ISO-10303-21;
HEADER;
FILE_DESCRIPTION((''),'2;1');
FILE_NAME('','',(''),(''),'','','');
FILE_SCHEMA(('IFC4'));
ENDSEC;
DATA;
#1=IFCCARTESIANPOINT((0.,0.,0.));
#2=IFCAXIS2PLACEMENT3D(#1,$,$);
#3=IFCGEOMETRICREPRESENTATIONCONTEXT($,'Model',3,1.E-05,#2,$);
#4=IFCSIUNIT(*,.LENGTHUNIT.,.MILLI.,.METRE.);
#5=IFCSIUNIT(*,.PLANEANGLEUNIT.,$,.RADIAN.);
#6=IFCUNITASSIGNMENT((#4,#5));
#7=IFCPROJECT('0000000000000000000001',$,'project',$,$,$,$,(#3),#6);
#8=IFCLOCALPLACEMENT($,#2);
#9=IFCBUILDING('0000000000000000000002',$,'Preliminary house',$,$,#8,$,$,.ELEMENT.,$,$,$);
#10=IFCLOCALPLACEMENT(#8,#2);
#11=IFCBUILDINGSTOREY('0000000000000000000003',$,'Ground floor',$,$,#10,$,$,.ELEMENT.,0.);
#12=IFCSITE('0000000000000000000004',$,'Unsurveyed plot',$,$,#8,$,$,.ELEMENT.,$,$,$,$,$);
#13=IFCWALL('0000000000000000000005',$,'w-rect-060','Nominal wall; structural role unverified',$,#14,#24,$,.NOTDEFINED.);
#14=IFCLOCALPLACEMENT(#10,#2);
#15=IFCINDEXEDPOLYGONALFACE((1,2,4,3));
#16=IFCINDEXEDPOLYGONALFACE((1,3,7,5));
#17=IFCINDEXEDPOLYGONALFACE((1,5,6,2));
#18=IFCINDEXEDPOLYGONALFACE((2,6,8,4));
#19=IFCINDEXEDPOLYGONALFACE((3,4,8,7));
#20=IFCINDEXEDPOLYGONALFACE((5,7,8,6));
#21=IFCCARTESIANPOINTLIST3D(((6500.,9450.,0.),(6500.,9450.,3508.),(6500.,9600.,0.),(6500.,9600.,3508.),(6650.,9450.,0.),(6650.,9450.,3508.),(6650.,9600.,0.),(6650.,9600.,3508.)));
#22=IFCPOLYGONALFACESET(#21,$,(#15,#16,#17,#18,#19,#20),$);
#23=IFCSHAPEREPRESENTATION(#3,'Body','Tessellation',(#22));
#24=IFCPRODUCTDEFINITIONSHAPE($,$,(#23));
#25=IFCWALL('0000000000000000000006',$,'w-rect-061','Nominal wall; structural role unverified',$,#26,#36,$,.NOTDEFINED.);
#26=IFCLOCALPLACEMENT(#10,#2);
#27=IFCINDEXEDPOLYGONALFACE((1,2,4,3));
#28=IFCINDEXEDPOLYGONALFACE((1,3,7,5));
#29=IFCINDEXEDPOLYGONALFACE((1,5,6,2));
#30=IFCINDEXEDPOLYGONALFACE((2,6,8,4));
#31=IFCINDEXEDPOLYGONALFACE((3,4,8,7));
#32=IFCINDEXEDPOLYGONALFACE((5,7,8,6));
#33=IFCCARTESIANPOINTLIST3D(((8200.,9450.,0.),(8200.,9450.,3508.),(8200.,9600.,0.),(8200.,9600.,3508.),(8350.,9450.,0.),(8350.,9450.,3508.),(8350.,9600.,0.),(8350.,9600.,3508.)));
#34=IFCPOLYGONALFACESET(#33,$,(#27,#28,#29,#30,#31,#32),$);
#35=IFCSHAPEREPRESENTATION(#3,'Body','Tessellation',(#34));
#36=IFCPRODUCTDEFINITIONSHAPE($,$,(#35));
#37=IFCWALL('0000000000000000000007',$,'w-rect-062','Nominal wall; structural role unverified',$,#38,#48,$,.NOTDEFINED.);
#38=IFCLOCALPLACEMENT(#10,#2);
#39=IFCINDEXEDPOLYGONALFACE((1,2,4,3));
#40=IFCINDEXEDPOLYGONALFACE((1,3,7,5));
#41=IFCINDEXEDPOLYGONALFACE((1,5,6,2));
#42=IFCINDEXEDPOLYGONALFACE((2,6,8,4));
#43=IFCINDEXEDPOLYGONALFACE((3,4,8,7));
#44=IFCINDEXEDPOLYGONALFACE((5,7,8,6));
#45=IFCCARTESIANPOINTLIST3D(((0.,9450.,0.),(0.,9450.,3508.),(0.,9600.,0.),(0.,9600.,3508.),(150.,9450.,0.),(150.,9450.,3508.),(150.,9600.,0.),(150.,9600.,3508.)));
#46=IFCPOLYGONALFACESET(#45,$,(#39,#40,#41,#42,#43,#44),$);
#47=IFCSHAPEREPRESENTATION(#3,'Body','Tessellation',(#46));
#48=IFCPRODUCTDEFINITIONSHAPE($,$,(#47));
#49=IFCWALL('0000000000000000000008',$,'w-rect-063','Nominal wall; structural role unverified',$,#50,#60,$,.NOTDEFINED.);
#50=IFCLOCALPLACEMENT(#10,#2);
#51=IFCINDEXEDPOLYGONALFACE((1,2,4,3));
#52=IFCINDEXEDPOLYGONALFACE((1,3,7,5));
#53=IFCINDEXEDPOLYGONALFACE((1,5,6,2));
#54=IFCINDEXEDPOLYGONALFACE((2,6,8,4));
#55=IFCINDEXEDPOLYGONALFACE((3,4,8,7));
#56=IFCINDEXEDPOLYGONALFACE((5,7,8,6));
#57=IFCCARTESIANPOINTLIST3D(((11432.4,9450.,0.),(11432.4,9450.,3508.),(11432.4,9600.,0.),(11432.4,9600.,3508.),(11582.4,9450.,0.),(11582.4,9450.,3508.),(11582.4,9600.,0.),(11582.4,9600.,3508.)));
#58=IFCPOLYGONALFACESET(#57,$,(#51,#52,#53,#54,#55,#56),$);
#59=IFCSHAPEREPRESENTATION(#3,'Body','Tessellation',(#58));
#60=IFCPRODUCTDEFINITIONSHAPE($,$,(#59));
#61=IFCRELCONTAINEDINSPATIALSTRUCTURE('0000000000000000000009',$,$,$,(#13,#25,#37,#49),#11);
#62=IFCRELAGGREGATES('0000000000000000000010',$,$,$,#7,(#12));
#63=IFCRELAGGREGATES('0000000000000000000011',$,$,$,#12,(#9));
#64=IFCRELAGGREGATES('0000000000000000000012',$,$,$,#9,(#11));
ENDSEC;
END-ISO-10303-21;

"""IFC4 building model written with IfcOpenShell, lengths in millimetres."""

from ifc_helpers import new_model, si_unit, origin, place, context, project, spatial, polyline, outline, extrude, element, save


model = new_model("IFC4")

# Units and contexts
model_context = context("Model", 3, precision=1e-05, world=origin())
ifc_project = project(units=[si_unit("LENGTHUNIT", "METRE", prefix="MILLI"), si_unit("PLANEANGLEUNIT", "RADIAN")], contexts=[model_context])

# Site, building, storey
placement_1 = place(None, origin())
site = spatial("IfcSite", under=ifc_project, at=placement_1, Name="Unsurveyed plot", CompositionType="ELEMENT")
building = spatial("IfcBuilding", under=site, at=placement_1, Name="Preliminary house", CompositionType="ELEMENT")
placement_2 = place(placement_1, origin())
storey = spatial("IfcBuildingStorey", under=building, at=placement_2, Name="Ground floor", CompositionType="ELEMENT", Elevation=0.0)

# Walls
element("IfcWall", 1, at=placement_2, inside=storey, Name="w-rect-060", Description="Nominal wall; structural role unverified", PredefinedType="NOTDEFINED", context=model_context, shape_type="SweptSolid", body=[
    extrude(outline(polyline([(6500.0, 9450.0), (6650.0, 9450.0), (6650.0, 9600.0), (6500.0, 9600.0), (6500.0, 9450.0)])), origin(), (0.0, 0.0, 1.0), 3508.0),
])
element("IfcWall", 2, at=placement_2, inside=storey, Name="w-rect-061", Description="Nominal wall; structural role unverified", PredefinedType="NOTDEFINED", context=model_context, shape_type="SweptSolid", body=[
    extrude(outline(polyline([(8200.0, 9450.0), (8350.0, 9450.0), (8350.0, 9600.0), (8200.0, 9600.0), (8200.0, 9450.0)])), origin(), (0.0, 0.0, 1.0), 3508.0),
])
element("IfcWall", 3, at=placement_2, inside=storey, Name="w-rect-062", Description="Nominal wall; structural role unverified", PredefinedType="NOTDEFINED", context=model_context, shape_type="SweptSolid", body=[
    extrude(outline(polyline([(0.0, 9450.0), (150.0, 9450.0), (150.0, 9600.0), (0.0, 9600.0), (0.0, 9450.0)])), origin(), (0.0, 0.0, 1.0), 3508.0),
])
element("IfcWall", 4, at=placement_2, inside=storey, Name="w-rect-063", Description="Nominal wall; structural role unverified", PredefinedType="NOTDEFINED", context=model_context, shape_type="SweptSolid", body=[
    extrude(outline(polyline([(11432.4, 9450.0), (11582.4, 9450.0), (11582.4, 9600.0), (11432.4, 9600.0), (11432.4, 9450.0)])), origin(), (0.0, 0.0, 1.0), 3508.0),
])

save(model, "model.ifc")
